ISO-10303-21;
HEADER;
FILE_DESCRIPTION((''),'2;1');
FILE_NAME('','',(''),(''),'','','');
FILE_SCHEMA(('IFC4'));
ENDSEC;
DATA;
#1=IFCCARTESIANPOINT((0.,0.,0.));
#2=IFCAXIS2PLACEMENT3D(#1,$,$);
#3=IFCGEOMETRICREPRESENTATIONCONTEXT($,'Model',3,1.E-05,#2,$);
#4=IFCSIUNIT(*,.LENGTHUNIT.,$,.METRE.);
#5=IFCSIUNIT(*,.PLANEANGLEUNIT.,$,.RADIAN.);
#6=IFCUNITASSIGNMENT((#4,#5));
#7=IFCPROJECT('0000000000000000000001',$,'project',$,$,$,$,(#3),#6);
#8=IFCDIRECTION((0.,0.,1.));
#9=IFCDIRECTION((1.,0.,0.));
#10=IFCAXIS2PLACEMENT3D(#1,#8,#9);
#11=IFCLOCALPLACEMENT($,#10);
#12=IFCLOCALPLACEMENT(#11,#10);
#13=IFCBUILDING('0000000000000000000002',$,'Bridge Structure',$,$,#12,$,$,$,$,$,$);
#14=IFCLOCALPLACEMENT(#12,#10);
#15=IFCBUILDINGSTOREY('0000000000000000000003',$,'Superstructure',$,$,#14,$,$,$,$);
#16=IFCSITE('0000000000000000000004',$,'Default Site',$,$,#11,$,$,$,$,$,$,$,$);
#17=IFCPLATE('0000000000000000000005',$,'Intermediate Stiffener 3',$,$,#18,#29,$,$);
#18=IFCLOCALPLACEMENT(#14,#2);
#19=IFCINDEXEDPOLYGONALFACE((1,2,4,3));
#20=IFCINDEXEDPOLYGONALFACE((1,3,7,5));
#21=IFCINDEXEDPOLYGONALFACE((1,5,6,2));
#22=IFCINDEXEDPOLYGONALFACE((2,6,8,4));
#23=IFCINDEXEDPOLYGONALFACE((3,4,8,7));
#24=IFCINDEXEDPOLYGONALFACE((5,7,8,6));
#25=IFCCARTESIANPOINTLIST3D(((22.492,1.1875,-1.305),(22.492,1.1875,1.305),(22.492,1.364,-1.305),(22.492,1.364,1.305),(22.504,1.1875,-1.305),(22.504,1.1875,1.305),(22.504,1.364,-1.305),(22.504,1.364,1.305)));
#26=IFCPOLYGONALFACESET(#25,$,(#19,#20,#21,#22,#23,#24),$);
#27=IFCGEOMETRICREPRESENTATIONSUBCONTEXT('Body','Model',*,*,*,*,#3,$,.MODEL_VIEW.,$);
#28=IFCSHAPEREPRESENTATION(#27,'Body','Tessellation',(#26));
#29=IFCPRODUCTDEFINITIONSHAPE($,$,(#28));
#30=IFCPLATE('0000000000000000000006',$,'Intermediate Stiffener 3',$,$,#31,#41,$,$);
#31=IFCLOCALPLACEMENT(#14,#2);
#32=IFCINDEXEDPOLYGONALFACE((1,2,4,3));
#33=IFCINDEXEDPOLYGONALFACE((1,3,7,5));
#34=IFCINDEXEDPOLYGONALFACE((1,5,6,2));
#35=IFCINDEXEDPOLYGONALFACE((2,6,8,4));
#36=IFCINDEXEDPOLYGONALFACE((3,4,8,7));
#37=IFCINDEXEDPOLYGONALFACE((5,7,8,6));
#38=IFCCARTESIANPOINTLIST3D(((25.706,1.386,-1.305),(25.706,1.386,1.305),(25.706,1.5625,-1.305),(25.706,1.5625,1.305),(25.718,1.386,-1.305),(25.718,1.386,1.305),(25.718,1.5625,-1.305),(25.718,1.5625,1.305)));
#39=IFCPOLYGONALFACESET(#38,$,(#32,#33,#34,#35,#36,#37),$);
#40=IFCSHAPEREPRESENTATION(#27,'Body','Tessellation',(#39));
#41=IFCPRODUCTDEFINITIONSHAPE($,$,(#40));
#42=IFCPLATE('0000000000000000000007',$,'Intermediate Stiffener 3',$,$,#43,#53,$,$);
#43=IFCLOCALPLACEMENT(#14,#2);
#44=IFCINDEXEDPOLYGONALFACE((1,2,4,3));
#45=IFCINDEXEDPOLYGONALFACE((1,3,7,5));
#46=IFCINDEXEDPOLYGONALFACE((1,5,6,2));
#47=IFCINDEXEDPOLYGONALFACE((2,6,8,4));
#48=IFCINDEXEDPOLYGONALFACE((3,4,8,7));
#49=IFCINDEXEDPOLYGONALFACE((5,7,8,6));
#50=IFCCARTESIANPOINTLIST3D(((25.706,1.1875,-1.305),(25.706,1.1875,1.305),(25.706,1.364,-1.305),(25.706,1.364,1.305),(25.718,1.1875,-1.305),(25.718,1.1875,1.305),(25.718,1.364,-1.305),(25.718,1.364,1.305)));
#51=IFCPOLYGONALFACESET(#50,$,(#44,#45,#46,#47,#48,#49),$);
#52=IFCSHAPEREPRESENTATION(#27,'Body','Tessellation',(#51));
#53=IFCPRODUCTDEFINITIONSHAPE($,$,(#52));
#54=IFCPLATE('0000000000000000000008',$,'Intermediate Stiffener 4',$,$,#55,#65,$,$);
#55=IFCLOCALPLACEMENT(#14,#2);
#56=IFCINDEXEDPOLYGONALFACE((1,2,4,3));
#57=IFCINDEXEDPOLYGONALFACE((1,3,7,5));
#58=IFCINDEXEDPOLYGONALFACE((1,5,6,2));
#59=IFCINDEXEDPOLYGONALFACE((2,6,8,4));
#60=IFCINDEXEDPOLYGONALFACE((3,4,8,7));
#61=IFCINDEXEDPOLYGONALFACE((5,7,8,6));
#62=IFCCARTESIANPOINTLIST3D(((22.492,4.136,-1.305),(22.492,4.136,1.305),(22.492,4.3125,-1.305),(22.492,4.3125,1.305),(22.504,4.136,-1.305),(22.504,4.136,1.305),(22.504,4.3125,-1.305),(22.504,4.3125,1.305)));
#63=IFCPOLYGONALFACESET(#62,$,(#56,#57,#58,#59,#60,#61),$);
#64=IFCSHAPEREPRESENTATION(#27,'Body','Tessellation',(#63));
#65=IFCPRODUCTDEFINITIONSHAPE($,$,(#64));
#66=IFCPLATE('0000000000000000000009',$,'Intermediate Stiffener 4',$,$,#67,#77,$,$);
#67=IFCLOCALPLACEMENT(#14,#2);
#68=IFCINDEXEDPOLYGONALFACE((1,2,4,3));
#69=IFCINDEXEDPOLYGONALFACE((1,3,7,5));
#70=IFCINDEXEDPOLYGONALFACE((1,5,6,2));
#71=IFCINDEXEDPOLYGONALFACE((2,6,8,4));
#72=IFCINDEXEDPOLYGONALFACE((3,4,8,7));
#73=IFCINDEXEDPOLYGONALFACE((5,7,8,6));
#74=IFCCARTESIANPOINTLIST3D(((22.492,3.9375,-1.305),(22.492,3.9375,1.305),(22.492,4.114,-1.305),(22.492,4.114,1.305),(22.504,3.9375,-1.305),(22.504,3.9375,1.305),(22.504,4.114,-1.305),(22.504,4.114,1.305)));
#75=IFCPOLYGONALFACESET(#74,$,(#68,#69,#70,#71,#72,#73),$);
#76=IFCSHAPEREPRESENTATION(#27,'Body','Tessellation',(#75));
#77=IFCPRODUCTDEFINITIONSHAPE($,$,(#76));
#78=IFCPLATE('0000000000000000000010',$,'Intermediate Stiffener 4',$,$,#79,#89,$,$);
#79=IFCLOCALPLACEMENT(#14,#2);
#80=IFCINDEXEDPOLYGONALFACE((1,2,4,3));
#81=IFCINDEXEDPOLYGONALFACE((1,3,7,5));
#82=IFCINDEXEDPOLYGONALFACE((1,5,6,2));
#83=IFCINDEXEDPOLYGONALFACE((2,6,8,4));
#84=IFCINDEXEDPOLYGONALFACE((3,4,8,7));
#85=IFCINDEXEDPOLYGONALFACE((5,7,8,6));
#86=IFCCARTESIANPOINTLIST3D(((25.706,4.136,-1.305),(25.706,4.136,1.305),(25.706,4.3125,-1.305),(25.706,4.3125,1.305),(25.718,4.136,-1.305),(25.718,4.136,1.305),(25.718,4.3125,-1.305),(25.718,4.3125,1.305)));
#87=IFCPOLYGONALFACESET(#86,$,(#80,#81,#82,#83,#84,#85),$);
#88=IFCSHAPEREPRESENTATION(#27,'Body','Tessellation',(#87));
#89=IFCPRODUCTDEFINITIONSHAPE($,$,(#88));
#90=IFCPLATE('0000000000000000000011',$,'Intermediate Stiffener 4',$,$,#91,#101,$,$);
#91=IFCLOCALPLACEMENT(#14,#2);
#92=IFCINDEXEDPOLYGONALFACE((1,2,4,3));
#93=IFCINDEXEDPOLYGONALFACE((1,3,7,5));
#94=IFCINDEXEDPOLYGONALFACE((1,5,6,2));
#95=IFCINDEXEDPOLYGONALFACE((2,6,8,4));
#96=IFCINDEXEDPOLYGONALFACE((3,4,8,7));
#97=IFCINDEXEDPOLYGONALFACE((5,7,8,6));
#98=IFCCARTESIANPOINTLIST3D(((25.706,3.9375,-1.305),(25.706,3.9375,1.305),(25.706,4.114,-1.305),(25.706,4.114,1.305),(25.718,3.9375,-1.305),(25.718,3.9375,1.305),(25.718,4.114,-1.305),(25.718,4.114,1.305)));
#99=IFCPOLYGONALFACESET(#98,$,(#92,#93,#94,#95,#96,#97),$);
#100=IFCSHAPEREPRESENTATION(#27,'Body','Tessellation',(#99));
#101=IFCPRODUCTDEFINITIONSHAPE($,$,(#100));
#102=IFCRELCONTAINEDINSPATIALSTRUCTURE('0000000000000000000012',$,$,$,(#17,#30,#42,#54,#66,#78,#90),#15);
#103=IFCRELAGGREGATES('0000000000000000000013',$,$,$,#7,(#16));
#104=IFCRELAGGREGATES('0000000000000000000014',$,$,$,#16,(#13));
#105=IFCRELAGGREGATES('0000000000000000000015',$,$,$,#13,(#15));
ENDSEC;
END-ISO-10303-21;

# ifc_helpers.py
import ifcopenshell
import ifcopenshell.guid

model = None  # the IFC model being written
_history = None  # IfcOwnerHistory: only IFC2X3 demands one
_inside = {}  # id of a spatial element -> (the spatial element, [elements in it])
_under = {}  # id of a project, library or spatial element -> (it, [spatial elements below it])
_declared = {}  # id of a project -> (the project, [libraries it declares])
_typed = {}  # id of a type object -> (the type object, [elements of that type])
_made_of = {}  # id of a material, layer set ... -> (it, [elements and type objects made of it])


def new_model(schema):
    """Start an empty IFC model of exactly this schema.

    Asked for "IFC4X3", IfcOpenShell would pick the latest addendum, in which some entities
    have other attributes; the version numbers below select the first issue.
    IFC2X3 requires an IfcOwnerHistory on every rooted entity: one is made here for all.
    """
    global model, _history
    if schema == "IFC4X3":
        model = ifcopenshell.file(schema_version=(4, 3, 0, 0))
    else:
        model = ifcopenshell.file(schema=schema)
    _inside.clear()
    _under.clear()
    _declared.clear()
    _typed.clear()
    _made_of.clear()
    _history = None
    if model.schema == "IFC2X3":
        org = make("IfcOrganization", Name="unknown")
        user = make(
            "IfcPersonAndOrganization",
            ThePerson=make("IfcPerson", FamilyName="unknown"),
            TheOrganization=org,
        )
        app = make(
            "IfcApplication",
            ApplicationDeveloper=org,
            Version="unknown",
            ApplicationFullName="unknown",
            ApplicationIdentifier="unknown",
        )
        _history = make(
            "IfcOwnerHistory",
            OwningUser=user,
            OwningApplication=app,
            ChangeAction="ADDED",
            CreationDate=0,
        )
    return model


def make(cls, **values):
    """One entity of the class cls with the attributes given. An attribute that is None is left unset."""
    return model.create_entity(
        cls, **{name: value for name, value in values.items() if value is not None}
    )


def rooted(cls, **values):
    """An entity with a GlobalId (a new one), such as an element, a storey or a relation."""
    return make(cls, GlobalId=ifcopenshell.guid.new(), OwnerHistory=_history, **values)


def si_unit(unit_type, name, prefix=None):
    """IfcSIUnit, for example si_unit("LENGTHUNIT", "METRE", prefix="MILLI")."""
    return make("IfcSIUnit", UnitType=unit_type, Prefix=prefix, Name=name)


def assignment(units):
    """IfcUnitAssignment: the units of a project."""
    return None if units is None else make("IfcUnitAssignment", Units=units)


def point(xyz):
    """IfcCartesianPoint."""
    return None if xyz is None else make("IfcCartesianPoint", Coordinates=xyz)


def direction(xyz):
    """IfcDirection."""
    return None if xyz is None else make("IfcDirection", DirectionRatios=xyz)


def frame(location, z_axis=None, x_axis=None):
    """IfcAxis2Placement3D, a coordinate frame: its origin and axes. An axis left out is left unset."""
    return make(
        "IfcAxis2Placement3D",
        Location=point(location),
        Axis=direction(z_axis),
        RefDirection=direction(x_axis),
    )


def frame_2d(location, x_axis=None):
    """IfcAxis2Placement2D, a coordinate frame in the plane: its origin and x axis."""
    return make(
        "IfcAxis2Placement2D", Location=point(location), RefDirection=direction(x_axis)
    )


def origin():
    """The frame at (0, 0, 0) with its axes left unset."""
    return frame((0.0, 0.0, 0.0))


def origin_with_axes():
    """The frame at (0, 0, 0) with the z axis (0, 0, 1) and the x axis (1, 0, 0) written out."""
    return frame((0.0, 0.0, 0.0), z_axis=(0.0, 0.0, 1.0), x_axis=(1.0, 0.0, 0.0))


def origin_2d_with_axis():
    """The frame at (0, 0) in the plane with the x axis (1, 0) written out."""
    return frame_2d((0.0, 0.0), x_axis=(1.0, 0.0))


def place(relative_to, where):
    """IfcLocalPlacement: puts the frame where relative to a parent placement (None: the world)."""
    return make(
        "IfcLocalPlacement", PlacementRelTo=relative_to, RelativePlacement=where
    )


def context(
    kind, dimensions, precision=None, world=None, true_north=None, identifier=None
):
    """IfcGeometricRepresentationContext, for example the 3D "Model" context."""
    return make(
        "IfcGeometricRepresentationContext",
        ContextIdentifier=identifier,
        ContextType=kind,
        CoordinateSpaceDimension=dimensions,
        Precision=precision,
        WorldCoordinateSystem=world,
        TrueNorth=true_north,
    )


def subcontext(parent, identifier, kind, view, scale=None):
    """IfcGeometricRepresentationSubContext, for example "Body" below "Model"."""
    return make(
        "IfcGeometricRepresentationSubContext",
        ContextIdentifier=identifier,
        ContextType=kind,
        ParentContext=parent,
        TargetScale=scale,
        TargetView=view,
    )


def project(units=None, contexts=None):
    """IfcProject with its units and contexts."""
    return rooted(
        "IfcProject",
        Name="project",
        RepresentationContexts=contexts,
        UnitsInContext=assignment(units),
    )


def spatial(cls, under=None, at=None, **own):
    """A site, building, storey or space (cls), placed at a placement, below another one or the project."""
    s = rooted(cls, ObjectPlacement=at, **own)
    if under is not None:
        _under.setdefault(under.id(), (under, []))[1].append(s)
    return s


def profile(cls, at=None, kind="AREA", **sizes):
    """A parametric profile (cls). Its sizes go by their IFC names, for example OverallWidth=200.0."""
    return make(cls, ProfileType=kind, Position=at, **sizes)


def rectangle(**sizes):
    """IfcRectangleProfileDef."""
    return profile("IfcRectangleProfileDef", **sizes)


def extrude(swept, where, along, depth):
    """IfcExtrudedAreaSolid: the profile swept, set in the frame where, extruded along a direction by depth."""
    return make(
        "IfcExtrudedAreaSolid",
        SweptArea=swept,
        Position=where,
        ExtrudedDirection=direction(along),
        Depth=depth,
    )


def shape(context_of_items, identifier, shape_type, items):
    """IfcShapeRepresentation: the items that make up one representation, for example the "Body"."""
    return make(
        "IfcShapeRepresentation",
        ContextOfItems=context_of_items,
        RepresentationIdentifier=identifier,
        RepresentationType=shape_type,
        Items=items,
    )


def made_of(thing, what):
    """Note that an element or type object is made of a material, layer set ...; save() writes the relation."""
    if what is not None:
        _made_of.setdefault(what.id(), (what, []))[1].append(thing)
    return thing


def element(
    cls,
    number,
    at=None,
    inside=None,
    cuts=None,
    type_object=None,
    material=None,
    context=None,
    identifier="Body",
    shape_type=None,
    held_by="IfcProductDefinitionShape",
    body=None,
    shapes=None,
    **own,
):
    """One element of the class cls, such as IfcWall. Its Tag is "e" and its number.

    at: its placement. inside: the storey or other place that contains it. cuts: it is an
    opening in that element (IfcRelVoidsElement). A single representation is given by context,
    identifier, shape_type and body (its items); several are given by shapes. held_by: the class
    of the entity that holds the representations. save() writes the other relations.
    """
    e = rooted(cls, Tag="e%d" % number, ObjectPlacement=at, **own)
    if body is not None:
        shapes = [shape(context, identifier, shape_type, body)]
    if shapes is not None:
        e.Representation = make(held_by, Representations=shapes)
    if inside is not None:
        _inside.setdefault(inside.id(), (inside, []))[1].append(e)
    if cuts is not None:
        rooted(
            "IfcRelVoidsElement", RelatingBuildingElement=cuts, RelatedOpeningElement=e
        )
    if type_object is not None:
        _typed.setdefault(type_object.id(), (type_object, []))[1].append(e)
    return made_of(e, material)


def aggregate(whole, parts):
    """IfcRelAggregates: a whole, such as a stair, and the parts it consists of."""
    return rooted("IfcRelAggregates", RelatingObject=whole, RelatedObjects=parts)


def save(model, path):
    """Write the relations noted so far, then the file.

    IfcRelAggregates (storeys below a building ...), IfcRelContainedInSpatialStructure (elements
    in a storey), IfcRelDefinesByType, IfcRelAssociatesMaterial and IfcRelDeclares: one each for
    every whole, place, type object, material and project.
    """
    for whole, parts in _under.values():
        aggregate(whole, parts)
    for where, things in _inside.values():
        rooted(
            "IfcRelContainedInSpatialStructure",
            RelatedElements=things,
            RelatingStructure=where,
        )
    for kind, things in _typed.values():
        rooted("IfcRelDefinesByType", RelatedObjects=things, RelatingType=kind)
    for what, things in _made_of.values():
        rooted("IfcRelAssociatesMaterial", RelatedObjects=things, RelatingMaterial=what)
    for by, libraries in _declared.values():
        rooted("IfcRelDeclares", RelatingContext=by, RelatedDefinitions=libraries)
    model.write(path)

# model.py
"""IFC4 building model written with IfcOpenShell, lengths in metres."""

from ifc_helpers import new_model, si_unit, frame, origin, origin_with_axes, origin_2d_with_axis, place, context, subcontext, project, spatial, rectangle, extrude, element, save


model = new_model("IFC4")

# Units and contexts
model_context = context("Model", 3, precision=1e-05, world=origin())
body_context = subcontext(model_context, "Body", "Model", "MODEL_VIEW")
ifc_project = project(units=[si_unit("LENGTHUNIT", "METRE"), si_unit("PLANEANGLEUNIT", "RADIAN")], contexts=[model_context])

# Site, building, storey
site_placement = place(None, origin_with_axes())
site = spatial("IfcSite", under=ifc_project, at=site_placement, Name="Default Site")
building_placement = place(site_placement, origin_with_axes())
building = spatial("IfcBuilding", under=site, at=building_placement, Name="Bridge Structure")
storey_placement = place(building_placement, origin_with_axes())
storey = spatial("IfcBuildingStorey", under=building, at=storey_placement, Name="Superstructure")

# Plates
for number, where, z_axis, x_axis, name in (
    (1, (22.498, 1.2757, -1.305), (0.0, 0.0, 1.0), (1.0, 0.0, 0.0), "Intermediate Stiffener 3"),
    (2, (25.712, 1.4743, -1.305), (0.0, 0.0, 1.0), (1.0, 0.0, 0.0), "Intermediate Stiffener 3"),
    (3, (25.712, 1.2757, -1.305), (0.0, 0.0, 1.0), (1.0, 0.0, 0.0), "Intermediate Stiffener 3"),
    (4, (22.498, 4.2243, -1.305), (0.0, 0.0, 1.0), (1.0, 0.0, 0.0), "Intermediate Stiffener 4"),
    (5, (22.498, 4.0258, -1.305), (0.0, 0.0, 1.0), (1.0, 0.0, 0.0), "Intermediate Stiffener 4"),
    (6, (25.712, 4.2243, -1.305), (0.0, 0.0, 1.0), (1.0, 0.0, 0.0), "Intermediate Stiffener 4"),
    (7, (25.712, 4.0258, -1.305), (0.0, 0.0, 1.0), (1.0, 0.0, 0.0), "Intermediate Stiffener 4"),
):
    element("IfcPlate", number, at=place(storey_placement, frame(where, z_axis=z_axis, x_axis=x_axis)), inside=storey, Name=name, context=body_context, shape_type="SweptSolid", body=[
        extrude(rectangle(XDim=0.012, YDim=0.1765, at=origin_2d_with_axis()), origin_with_axes(), (0.0, 0.0, 1.0), 2.61),
    ])

save(model, "model.ifc")
